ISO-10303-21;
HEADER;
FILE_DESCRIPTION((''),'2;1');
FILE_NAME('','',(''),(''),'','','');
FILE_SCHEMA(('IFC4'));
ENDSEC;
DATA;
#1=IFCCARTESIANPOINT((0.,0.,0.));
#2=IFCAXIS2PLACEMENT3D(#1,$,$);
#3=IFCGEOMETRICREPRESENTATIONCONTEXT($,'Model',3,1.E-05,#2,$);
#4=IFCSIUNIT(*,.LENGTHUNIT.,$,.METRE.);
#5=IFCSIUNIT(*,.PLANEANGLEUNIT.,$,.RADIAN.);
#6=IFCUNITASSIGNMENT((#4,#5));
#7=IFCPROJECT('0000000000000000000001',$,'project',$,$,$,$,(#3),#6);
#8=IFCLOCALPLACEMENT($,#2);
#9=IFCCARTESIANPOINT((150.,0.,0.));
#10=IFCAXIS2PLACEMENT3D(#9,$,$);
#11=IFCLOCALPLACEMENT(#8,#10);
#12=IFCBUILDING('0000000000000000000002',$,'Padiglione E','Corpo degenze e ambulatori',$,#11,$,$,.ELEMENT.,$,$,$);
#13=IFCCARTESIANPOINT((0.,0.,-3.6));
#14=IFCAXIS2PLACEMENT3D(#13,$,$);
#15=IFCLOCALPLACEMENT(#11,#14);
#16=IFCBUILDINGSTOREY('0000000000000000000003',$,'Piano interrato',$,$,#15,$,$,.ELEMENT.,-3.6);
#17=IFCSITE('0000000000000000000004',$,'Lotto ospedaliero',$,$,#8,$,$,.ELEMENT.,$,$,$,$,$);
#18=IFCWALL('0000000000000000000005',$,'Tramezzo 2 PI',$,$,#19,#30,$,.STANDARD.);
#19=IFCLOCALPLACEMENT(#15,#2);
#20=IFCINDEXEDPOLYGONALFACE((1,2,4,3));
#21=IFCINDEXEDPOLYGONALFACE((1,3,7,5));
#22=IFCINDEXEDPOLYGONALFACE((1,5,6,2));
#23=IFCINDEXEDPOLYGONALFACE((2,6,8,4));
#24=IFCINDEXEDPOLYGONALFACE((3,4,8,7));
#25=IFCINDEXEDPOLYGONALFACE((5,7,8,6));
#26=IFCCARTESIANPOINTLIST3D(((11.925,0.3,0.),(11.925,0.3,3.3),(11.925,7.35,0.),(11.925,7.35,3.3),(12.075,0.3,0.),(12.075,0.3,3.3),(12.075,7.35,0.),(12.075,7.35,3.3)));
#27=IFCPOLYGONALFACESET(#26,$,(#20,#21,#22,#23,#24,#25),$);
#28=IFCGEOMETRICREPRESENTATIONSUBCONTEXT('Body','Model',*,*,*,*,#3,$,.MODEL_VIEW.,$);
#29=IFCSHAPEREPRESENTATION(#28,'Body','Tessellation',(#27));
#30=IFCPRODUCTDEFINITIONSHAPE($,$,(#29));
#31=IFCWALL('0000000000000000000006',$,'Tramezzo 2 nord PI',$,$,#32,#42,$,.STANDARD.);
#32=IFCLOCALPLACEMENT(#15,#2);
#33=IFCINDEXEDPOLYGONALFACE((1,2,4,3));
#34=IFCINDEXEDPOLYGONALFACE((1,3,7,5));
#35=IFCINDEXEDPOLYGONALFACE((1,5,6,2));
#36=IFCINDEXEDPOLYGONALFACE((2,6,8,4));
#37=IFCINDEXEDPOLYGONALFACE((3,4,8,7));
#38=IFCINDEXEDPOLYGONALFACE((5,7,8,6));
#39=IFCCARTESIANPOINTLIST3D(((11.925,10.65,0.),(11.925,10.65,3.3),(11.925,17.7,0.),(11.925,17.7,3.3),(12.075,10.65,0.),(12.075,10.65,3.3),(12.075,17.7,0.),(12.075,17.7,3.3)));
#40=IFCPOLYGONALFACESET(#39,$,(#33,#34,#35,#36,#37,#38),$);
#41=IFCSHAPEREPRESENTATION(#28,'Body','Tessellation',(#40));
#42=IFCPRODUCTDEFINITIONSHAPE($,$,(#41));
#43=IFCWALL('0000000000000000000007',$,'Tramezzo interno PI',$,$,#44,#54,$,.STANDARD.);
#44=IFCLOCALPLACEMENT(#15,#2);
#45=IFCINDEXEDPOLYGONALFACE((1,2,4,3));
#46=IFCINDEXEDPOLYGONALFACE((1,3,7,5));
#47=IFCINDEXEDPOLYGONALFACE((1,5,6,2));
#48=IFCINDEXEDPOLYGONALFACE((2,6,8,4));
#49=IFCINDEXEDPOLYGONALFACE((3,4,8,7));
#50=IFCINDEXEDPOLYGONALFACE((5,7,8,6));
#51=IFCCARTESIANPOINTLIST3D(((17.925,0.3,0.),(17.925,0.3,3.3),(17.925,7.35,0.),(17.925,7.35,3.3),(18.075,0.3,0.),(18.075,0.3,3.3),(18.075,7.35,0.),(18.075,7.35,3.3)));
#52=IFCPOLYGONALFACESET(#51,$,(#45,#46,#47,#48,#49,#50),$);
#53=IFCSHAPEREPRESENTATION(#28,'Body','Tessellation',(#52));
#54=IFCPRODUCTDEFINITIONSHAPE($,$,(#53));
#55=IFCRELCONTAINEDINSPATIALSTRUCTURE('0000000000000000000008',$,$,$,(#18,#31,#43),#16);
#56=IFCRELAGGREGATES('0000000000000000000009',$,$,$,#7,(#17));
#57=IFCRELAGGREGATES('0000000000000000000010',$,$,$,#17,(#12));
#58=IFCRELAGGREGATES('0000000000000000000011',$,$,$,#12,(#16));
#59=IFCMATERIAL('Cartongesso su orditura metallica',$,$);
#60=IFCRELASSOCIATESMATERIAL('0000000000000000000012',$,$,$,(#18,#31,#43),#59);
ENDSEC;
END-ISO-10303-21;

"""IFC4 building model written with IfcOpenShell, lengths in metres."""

from ifc_helpers import new_model, si_unit, frame, frame_2d, origin, place, context, subcontext, project, spatial, rectangle, extrude, material, element, save


model = new_model("IFC4")

# Units and contexts
model_context = context("Model", 3, precision=1e-05, world=origin())
body_context = subcontext(model_context, "Body", "Model", "MODEL_VIEW")
ifc_project = project(units=[si_unit("LENGTHUNIT", "METRE"), si_unit("PLANEANGLEUNIT", "RADIAN")], contexts=[model_context])

# Site, building, storey
site_placement = place(None, origin())
site = spatial("IfcSite", under=ifc_project, at=site_placement, Name="Lotto ospedaliero", CompositionType="ELEMENT")
building_placement = place(site_placement, frame((150.0, 0.0, 0.0)))
building = spatial("IfcBuilding", under=site, at=building_placement, Name="Padiglione E", Description="Corpo degenze e ambulatori", CompositionType="ELEMENT")
storey_placement = place(building_placement, frame((0.0, 0.0, -3.6)))
storey = spatial("IfcBuildingStorey", under=building, at=storey_placement, Name="Piano interrato", CompositionType="ELEMENT", Elevation=-3.6)

# Walls
ifc_material_1 = material(Name="Cartongesso su orditura metallica")
for number, where, name in (
    (1, (11.925, 0.3, 0.0), "Tramezzo 2 PI"),
    (2, (11.925, 10.65, 0.0), "Tramezzo 2 nord PI"),
    (3, (17.925, 0.3, 0.0), "Tramezzo interno PI"),
):
    element("IfcWall", number, at=place(storey_placement, frame(where)), inside=storey, material=ifc_material_1, Name=name, PredefinedType="STANDARD", context=body_context, shape_type="SweptSolid", body=[
        extrude(rectangle(XDim=0.15, YDim=7.05, at=frame_2d((0.075, 3.525))), origin(), (0.0, 0.0, 1.0), 3.3),
    ])

save(model, "model.ifc")
